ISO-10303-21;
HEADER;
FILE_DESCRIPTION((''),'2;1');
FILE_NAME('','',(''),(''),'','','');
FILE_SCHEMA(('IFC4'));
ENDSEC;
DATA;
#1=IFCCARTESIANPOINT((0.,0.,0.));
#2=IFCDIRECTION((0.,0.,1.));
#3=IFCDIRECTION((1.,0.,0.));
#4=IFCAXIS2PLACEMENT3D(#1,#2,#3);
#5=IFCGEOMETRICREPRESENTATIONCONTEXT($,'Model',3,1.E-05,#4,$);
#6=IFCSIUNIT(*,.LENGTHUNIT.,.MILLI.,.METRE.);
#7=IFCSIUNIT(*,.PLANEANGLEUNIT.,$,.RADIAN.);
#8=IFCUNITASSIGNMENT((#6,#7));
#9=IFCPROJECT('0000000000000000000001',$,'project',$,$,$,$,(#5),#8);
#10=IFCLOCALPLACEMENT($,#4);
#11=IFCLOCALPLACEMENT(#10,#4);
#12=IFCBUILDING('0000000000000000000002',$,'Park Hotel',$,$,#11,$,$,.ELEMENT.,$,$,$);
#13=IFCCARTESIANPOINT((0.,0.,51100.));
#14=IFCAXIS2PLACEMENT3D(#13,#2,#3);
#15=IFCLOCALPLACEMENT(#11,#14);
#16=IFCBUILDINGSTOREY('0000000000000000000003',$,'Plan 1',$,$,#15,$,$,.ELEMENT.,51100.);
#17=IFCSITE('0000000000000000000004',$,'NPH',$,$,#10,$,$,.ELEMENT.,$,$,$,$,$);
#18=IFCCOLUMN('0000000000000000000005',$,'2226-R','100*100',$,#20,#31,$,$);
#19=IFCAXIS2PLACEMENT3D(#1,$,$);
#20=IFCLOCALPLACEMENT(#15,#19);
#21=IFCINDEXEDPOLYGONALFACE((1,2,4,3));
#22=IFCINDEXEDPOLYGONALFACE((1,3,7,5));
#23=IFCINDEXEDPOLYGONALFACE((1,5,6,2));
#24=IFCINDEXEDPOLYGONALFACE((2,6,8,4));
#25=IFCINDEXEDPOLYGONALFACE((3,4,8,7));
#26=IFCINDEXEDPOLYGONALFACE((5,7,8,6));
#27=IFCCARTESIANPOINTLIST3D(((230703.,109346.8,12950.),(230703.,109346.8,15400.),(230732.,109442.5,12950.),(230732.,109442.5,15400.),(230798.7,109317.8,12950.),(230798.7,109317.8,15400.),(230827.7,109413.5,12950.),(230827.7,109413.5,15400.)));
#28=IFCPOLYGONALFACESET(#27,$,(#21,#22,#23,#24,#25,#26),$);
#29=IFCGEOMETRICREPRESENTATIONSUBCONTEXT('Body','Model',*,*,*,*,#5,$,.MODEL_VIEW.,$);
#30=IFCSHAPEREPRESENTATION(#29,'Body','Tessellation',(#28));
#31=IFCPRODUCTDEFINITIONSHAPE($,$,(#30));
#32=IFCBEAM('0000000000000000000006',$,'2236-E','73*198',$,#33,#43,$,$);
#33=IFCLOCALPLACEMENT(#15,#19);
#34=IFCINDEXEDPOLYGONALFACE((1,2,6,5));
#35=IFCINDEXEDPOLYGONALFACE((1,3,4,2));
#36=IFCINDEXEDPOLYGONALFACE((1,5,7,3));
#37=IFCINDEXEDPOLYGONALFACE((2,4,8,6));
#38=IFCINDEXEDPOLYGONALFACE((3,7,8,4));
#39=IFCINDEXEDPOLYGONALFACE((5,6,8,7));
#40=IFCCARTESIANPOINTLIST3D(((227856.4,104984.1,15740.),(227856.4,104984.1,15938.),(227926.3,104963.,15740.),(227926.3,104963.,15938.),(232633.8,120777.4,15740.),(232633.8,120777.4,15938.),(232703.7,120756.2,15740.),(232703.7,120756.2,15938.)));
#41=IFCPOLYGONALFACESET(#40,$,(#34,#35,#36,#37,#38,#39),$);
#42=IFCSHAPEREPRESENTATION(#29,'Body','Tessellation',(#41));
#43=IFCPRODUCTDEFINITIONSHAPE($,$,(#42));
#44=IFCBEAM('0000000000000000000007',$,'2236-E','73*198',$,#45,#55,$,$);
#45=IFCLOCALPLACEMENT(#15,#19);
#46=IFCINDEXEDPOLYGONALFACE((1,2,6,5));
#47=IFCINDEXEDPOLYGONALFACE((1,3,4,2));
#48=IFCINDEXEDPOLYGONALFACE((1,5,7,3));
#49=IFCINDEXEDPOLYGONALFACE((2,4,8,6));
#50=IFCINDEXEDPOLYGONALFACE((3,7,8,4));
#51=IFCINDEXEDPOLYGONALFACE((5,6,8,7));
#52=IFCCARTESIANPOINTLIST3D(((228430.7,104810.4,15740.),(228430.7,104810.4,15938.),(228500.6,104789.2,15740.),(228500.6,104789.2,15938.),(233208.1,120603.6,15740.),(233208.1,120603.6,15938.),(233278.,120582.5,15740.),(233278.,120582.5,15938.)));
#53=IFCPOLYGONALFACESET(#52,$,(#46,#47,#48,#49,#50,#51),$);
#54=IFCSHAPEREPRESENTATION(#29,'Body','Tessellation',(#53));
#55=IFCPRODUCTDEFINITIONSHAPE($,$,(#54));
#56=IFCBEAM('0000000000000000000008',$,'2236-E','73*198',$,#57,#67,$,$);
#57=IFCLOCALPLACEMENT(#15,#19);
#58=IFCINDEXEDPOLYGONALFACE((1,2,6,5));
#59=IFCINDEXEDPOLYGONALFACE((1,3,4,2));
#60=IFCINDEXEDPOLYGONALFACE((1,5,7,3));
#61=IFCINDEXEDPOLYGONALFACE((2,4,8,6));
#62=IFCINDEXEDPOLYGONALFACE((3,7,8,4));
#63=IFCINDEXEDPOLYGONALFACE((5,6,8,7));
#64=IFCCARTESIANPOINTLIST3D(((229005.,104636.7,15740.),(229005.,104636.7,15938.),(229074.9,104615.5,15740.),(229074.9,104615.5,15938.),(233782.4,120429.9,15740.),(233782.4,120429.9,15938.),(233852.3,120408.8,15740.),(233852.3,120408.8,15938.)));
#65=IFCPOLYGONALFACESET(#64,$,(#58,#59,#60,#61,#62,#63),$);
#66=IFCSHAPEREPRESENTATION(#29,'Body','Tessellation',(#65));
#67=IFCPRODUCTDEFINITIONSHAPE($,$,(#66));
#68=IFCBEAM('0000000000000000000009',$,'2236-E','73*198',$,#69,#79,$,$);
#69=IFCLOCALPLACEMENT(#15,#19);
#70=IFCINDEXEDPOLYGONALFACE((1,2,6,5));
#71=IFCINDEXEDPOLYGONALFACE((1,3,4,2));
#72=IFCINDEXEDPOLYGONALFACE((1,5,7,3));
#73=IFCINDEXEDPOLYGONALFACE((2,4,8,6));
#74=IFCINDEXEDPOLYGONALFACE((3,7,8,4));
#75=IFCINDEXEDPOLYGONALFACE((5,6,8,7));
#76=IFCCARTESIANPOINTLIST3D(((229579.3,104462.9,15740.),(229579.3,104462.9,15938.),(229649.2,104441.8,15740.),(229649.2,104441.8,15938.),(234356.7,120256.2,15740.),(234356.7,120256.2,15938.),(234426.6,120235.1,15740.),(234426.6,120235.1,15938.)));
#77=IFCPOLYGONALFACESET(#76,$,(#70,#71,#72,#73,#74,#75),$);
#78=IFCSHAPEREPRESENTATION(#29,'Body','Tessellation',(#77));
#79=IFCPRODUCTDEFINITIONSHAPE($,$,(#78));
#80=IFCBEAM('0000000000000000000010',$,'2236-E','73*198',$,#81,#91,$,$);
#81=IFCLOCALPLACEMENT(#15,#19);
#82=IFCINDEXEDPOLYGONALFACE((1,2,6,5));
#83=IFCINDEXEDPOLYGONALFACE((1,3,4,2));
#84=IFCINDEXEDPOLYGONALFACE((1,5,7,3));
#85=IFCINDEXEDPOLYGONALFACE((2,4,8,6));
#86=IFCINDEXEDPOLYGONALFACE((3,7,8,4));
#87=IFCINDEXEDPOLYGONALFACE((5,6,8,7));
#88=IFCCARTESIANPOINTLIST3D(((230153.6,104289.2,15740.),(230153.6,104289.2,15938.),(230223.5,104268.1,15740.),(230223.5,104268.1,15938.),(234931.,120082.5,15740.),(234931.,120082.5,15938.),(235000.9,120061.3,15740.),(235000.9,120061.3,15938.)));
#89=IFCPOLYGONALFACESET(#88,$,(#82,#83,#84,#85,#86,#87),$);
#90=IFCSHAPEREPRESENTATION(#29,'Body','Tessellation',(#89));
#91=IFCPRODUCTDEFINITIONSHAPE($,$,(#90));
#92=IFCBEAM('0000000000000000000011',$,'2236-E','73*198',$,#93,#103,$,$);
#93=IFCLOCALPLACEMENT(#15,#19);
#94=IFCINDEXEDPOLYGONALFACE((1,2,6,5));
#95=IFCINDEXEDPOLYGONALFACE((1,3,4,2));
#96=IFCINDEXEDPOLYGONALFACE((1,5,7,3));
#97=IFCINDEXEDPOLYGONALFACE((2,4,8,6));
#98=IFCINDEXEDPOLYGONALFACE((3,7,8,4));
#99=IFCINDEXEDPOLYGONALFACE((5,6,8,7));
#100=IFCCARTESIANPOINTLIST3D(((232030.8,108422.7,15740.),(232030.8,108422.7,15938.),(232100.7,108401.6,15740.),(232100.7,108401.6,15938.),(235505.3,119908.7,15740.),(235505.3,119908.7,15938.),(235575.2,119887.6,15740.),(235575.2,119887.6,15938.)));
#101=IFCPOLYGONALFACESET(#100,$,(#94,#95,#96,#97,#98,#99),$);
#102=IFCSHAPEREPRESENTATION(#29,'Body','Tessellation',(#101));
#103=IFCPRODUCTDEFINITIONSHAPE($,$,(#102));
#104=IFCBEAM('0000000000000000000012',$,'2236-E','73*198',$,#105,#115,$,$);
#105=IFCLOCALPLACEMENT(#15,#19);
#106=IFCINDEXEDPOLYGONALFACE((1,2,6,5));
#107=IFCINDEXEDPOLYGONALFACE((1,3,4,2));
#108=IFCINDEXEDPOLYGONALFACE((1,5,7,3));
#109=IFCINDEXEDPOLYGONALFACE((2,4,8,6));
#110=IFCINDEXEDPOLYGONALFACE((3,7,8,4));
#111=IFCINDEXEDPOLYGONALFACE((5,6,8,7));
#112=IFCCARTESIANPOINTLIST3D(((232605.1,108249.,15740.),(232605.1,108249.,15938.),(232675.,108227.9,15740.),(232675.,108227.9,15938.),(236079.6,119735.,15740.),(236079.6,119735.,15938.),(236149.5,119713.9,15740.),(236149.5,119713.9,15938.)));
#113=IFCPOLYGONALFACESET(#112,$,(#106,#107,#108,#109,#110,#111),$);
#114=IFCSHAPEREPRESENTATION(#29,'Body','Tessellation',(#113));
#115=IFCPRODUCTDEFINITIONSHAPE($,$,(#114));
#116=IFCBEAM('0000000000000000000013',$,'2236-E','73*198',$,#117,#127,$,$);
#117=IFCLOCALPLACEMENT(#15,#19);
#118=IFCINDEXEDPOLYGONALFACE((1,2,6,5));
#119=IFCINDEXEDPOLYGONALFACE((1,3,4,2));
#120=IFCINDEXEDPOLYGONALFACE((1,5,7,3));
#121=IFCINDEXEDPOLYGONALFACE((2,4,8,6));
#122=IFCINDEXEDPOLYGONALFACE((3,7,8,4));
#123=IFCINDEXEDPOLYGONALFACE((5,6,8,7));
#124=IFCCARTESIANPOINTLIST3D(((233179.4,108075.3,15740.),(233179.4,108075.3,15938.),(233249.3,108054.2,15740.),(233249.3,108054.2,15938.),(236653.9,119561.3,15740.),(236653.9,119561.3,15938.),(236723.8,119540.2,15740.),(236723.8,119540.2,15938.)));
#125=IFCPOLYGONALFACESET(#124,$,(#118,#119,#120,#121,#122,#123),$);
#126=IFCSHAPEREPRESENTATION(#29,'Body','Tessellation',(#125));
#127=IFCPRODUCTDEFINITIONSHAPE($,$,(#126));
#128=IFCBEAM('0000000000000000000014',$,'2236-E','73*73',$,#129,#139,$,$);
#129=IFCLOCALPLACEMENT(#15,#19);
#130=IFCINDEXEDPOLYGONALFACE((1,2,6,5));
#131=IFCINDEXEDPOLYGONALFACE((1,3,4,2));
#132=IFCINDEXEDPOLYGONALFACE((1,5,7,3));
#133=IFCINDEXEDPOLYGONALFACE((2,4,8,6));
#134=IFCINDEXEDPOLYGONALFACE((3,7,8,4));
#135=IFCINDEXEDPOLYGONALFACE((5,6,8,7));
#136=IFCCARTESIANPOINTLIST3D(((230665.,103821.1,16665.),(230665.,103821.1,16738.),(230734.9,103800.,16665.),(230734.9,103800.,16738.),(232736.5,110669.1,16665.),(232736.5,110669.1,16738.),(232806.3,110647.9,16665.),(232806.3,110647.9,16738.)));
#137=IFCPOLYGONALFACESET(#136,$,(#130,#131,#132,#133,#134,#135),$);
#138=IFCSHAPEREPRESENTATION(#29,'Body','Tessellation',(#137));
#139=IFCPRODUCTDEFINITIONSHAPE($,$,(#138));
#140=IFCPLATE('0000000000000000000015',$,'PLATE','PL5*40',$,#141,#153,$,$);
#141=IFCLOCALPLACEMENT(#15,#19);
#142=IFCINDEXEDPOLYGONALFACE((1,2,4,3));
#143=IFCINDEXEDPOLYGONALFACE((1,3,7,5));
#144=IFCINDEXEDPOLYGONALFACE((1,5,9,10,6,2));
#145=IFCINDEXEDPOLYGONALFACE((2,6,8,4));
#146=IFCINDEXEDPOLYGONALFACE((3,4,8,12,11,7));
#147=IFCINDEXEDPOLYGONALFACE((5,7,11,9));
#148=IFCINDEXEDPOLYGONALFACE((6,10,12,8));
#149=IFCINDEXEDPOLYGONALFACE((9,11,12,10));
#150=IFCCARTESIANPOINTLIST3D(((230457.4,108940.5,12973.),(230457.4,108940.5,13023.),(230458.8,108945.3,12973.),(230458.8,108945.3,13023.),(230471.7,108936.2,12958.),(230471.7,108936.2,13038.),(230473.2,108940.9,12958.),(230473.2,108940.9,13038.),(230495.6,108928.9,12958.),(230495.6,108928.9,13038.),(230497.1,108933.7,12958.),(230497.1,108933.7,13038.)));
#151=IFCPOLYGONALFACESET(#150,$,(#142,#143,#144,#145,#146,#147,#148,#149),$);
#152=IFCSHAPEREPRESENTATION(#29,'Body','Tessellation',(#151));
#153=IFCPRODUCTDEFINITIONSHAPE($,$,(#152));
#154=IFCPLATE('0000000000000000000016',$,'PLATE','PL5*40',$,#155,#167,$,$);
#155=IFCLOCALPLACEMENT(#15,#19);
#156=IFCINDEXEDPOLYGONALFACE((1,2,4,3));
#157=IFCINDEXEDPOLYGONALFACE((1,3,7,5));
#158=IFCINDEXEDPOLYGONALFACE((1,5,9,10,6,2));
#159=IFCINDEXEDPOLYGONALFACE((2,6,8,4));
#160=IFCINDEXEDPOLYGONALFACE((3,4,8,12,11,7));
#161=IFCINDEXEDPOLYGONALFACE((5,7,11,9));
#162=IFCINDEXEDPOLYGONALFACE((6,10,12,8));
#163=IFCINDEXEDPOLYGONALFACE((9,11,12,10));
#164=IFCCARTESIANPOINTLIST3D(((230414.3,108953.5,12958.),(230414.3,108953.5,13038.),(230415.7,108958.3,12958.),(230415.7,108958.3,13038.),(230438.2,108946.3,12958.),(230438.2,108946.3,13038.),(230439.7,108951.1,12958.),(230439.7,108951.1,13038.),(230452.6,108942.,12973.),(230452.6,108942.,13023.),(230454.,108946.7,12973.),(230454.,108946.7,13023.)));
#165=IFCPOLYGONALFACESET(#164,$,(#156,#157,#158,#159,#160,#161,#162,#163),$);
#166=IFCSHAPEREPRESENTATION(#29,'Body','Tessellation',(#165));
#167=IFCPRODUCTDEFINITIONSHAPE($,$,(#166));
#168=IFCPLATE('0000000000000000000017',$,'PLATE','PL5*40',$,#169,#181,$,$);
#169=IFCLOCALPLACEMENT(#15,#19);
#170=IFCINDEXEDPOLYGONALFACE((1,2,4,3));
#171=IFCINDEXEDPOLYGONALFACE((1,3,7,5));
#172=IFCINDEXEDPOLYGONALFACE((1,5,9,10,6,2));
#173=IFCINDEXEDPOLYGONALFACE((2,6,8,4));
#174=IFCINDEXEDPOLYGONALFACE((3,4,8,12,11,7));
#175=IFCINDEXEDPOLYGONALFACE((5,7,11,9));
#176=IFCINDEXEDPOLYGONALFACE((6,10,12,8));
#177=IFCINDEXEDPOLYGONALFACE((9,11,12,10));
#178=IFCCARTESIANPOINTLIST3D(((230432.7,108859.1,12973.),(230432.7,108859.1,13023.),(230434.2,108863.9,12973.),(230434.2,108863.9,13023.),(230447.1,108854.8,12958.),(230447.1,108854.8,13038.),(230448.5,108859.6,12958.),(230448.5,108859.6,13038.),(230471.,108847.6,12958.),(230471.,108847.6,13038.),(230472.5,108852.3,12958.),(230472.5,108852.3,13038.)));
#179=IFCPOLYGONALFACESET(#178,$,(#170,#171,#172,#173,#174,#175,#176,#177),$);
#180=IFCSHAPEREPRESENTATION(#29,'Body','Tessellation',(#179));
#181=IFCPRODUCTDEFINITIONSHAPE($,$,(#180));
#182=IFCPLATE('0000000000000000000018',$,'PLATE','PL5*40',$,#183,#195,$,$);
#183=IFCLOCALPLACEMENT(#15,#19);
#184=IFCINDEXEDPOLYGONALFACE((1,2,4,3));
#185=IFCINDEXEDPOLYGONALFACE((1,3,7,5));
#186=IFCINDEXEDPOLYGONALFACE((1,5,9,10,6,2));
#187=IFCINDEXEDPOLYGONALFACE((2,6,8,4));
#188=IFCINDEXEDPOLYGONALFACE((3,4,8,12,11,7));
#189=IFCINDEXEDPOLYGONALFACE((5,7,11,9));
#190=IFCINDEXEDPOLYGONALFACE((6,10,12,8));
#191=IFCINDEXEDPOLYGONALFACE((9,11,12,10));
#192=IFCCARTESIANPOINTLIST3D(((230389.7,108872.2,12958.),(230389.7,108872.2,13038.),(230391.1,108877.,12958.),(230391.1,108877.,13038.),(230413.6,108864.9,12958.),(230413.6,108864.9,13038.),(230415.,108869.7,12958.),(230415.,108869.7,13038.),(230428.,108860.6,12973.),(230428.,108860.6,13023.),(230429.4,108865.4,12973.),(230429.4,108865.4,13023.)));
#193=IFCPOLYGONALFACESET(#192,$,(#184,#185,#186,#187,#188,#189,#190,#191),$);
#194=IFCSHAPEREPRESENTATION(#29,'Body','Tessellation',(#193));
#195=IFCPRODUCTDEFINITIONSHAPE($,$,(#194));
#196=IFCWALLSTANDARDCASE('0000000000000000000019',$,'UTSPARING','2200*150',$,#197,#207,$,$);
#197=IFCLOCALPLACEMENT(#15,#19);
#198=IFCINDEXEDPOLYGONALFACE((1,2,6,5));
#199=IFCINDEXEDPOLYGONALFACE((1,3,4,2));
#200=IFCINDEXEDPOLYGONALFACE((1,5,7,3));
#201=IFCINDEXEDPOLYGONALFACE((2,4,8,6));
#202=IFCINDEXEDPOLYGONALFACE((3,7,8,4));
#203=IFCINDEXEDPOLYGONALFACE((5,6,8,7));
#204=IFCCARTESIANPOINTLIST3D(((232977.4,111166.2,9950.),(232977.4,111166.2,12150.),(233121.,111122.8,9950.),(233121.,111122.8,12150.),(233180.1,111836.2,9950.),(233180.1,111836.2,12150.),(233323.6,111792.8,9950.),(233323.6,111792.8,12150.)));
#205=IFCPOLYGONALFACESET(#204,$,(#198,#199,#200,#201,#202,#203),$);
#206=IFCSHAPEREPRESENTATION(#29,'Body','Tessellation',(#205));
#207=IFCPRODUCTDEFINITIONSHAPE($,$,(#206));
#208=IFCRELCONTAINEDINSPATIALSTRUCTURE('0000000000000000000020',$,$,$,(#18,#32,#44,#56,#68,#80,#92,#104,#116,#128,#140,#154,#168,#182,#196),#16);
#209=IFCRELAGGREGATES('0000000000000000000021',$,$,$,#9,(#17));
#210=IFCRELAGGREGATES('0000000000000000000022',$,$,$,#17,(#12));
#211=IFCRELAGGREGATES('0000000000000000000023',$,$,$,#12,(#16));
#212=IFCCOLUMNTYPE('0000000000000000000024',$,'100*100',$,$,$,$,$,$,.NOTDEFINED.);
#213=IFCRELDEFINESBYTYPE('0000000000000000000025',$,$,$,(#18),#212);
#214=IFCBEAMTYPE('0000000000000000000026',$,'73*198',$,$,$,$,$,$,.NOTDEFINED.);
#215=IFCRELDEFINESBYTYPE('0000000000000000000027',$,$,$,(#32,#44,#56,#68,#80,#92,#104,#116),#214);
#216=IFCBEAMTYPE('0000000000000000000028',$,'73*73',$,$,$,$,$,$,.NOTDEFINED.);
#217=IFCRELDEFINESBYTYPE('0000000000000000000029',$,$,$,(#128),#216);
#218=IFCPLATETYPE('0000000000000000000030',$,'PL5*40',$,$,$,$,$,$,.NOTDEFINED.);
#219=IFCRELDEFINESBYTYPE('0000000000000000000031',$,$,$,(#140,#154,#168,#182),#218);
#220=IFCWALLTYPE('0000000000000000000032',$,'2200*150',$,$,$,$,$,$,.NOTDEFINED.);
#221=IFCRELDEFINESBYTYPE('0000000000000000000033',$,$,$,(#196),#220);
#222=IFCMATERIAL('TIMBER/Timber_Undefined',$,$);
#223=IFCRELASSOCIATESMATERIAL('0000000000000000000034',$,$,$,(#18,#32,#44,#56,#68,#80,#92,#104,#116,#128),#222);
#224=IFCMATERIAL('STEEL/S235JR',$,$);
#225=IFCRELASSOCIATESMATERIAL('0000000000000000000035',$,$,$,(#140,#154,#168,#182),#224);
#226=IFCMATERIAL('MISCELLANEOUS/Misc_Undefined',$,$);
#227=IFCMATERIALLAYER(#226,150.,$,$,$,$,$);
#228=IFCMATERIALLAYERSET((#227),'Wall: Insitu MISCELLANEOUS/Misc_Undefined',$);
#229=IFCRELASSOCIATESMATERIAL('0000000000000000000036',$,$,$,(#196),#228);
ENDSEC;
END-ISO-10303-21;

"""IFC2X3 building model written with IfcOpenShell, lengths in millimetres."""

from ifc_helpers import new_model, si_unit, frame, frame_2d, origin_with_axes, origin_2d_with_axis, place, context, subcontext, project, spatial, polyline, rectangle, outline, extrude, material, layer, layer_set, layer_usage, type_object, element, save


model = new_model("IFC2X3")

# Units and contexts
model_context = context("Model", 3, precision=1e-05, world=origin_with_axes())
body_context = subcontext(model_context, "Body", "Model", "MODEL_VIEW")
ifc_project = project(units=[si_unit("LENGTHUNIT", "METRE", prefix="MILLI"), si_unit("PLANEANGLEUNIT", "RADIAN")], contexts=[model_context])

# Site, building, storey
site_placement = place(None, origin_with_axes())
site = spatial("IfcSite", under=ifc_project, at=site_placement, Name="NPH", CompositionType="ELEMENT")
building_placement = place(site_placement, origin_with_axes())
building = spatial("IfcBuilding", under=site, at=building_placement, Name="Park Hotel", CompositionType="ELEMENT")
storey_placement = place(building_placement, frame((0.0, 0.0, 51100.0), z_axis=(0.0, 0.0, 1.0), x_axis=(1.0, 0.0, 0.0)))
storey = spatial("IfcBuildingStorey", under=building, at=storey_placement, Name="Plan 1", CompositionType="ELEMENT", Elevation=51100.0)

# Column
ifc_material_1 = material(Name="TIMBER/Timber_Undefined")
column_type = type_object("IfcColumnType", Name="100*100", PredefinedType="NOTDEFINED")
column_placement = place(storey_placement, frame((230765.3, 109380.2, 15400.0), z_axis=(0.0, 0.0, -1.0), x_axis=(0.289538, 0.957167, 0.0)))
element("IfcColumn", 1, at=column_placement, inside=storey, type_object=column_type, material=ifc_material_1, Name="2226-R", Description="100*100", context=body_context, shape_type="SweptSolid", body=[
    extrude(rectangle(XDim=100.0, YDim=100.0, at=origin_2d_with_axis()), frame((0.0, 0.0, 2450.0), z_axis=(0.0, 0.0, -1.0), x_axis=(0.0, 1.0, 0.0)), (0.0, 0.0, 1.0), 2450.0),
])

# Beams
beam_type_1 = type_object("IfcBeamType", Name="73*198", PredefinedType="NOTDEFINED")
for number, where, z_axis, x_axis, name in (
    (2, (227891.4, 104973.5, 15839.0), (-0.957167, 0.289538, 0.0), (0.289538, 0.957167, 0.0), "2236-E"),
    (3, (228465.7, 104799.8, 15839.0), (-0.957167, 0.289538, 0.0), (0.289538, 0.957167, 0.0), "2236-E"),
    (4, (229040.0, 104626.1, 15839.0), (-0.957167, 0.289538, 0.0), (0.289538, 0.957167, 0.0), "2236-E"),
    (5, (229614.3, 104452.4, 15839.0), (-0.957167, 0.289538, 0.0), (0.289538, 0.957167, 0.0), "2236-E"),
    (6, (230188.6, 104278.6, 15839.0), (-0.957167, 0.289538, 0.0), (0.289538, 0.957167, 0.0), "2236-E"),
):
    element("IfcBeam", number, at=place(storey_placement, frame(where, z_axis=z_axis, x_axis=x_axis)), inside=storey, type_object=beam_type_1, material=ifc_material_1, Name=name, Description="73*198", context=body_context, shape_type="SweptSolid", body=[
        extrude(rectangle(XDim=198.0, YDim=73.0, at=origin_2d_with_axis()), frame((16500.0, 0.0, 0.0), z_axis=(-1.0, 0.0, 0.0), x_axis=(0.0, -1.0, 0.0)), (0.0, 0.0, 1.0), 16500.0),
    ])
for number, where, z_axis, x_axis, name in (
    (7, (232065.8, 108412.2, 15839.0), (-0.957167, 0.289538, 0.0), (0.289538, 0.957167, 0.0), "2236-E"),
    (8, (232640.1, 108238.5, 15839.0), (-0.957167, 0.289538, 0.0), (0.289538, 0.957167, 0.0), "2236-E"),
    (9, (233214.4, 108064.7, 15839.0), (-0.957167, 0.289538, 0.0), (0.289538, 0.957167, 0.0), "2236-E"),
):
    element("IfcBeam", number, at=place(storey_placement, frame(where, z_axis=z_axis, x_axis=x_axis)), inside=storey, type_object=beam_type_1, material=ifc_material_1, Name=name, Description="73*198", context=body_context, shape_type="SweptSolid", body=[
        extrude(rectangle(XDim=198.0, YDim=73.0, at=origin_2d_with_axis()), frame((12000.0, 0.0, 0.0), z_axis=(-1.0, 0.0, 0.0), x_axis=(0.0, -1.0, 0.0)), (0.0, 0.0, 1.0), 12000.0),
    ])
beam_type_2 = type_object("IfcBeamType", Name="73*73", PredefinedType="NOTDEFINED")
beam_1_placement = place(storey_placement, frame((230699.9, 103810.5, 16701.5), z_axis=(-0.957167, 0.289538, 0.0), x_axis=(0.289538, 0.957167, 0.0)))
element("IfcBeam", 10, at=beam_1_placement, inside=storey, type_object=beam_type_2, material=ifc_material_1, Name="2236-E", Description="73*73", context=body_context, shape_type="SweptSolid", body=[
    extrude(rectangle(XDim=73.0, YDim=73.0, at=origin_2d_with_axis()), frame((7154.4, 0.0, 0.0), z_axis=(-1.0, 0.0, 0.0), x_axis=(0.0, -1.0, 0.0)), (0.0, 0.0, 1.0), 7154.4),
])

# Plates
ifc_material_2 = material(Name="STEEL/S235JR")
plate_type = type_object("IfcPlateType", Name="PL5*40", PredefinedType="NOTDEFINED")
plate_1_placement = place(storey_placement, frame((230496.4, 108931.3, 12958.0), z_axis=(0.289538, 0.957167, 0.0), x_axis=(-0.957167, 0.289538, 0.0)))
element("IfcPlate", 11, at=plate_1_placement, inside=storey, type_object=plate_type, material=ifc_material_2, Name="PLATE", Description="PL5*40", context=body_context, shape_type="SweptSolid", body=[
    extrude(outline(polyline([(0.0, 0.0), (25.0, 0.0), (40.0, 15.0), (40.0, 65.0), (25.0, 80.0), (0.0, 80.0), (0.0, 0.0)])), frame((0.0, 0.0, -2.5), z_axis=(0.0, 0.0, 1.0), x_axis=(1.0, 0.0, 0.0)), (0.0, 0.0, 1.0), 5.0),
])
plate_2_placement = place(storey_placement, frame((230453.3, 108944.3, 12958.0), z_axis=(0.289538, 0.957167, 0.0), x_axis=(-0.957167, 0.289538, 0.0)))
element("IfcPlate", 12, at=plate_2_placement, inside=storey, type_object=plate_type, material=ifc_material_2, Name="PLATE", Description="PL5*40", context=body_context, shape_type="SweptSolid", body=[
    extrude(outline(polyline([(0.0, 15.0), (15.0, 0.0), (40.0, 0.0), (40.0, 80.0), (15.0, 80.0), (0.0, 65.0), (0.0, 15.0)])), frame((0.0, 0.0, -2.5), z_axis=(0.0, 0.0, 1.0), x_axis=(1.0, 0.0, 0.0)), (0.0, 0.0, 1.0), 5.0),
])
plate_3_placement = place(storey_placement, frame((230471.8, 108850.0, 12958.0), z_axis=(0.289538, 0.957167, 0.0), x_axis=(-0.957167, 0.289538, 0.0)))
element("IfcPlate", 13, at=plate_3_placement, inside=storey, type_object=plate_type, material=ifc_material_2, Name="PLATE", Description="PL5*40", context=body_context, shape_type="SweptSolid", body=[
    extrude(outline(polyline([(0.0, 0.0), (25.0, 0.0), (40.0, 15.0), (40.0, 65.0), (25.0, 80.0), (0.0, 80.0), (0.0, 0.0)])), frame((0.0, 0.0, -2.5), z_axis=(0.0, 0.0, 1.0), x_axis=(1.0, 0.0, 0.0)), (0.0, 0.0, 1.0), 5.0),
])
plate_4_placement = place(storey_placement, frame((230428.7, 108863.0, 12958.0), z_axis=(0.289538, 0.957167, 0.0), x_axis=(-0.957167, 0.289538, 0.0)))
element("IfcPlate", 14, at=plate_4_placement, inside=storey, type_object=plate_type, material=ifc_material_2, Name="PLATE", Description="PL5*40", context=body_context, shape_type="SweptSolid", body=[
    extrude(outline(polyline([(0.0, 15.0), (15.0, 0.0), (40.0, 0.0), (40.0, 80.0), (15.0, 80.0), (0.0, 65.0), (0.0, 15.0)])), frame((0.0, 0.0, -2.5), z_axis=(0.0, 0.0, 1.0), x_axis=(1.0, 0.0, 0.0)), (0.0, 0.0, 1.0), 5.0),
])

# Wall
ifc_material_3 = material(Name="MISCELLANEOUS/Misc_Undefined")
ifc_layer_1 = layer(ifc_material_3, 150.0)
ifc_layer_set_1 = layer_set([ifc_layer_1], Name="Wall: Insitu MISCELLANEOUS/Misc_Undefined")
ifc_layer_usage_1 = layer_usage(ifc_layer_set_1, "AXIS2", "POSITIVE", -75.0)
wall_type_1 = type_object("IfcWallType", Name="2200*150", PredefinedType="NOTDEFINED")
wall_1_placement = place(storey_placement, frame((233049.2, 111144.5, 9950.0), z_axis=(0.0, 0.0, 1.0), x_axis=(0.289542, 0.957165, 0.0)))
element("IfcWallStandardCase", 15, at=wall_1_placement, inside=storey, type_object=wall_type_1, material=ifc_layer_usage_1, Name="UTSPARING", Description="2200*150", context=body_context, shape_type="SweptSolid", body=[
    extrude(rectangle(XDim=700.0, YDim=150.0, at=frame_2d((0.0, 350.0), x_axis=(0.0, -1.0))), frame((0.0, 0.0, 0.0), z_axis=(0.0, 0.0, 1.0), x_axis=(0.0, -1.0, 0.0)), (0.0, 0.0, 1.0), 2200.0),
])

save(model, "model.ifc")
